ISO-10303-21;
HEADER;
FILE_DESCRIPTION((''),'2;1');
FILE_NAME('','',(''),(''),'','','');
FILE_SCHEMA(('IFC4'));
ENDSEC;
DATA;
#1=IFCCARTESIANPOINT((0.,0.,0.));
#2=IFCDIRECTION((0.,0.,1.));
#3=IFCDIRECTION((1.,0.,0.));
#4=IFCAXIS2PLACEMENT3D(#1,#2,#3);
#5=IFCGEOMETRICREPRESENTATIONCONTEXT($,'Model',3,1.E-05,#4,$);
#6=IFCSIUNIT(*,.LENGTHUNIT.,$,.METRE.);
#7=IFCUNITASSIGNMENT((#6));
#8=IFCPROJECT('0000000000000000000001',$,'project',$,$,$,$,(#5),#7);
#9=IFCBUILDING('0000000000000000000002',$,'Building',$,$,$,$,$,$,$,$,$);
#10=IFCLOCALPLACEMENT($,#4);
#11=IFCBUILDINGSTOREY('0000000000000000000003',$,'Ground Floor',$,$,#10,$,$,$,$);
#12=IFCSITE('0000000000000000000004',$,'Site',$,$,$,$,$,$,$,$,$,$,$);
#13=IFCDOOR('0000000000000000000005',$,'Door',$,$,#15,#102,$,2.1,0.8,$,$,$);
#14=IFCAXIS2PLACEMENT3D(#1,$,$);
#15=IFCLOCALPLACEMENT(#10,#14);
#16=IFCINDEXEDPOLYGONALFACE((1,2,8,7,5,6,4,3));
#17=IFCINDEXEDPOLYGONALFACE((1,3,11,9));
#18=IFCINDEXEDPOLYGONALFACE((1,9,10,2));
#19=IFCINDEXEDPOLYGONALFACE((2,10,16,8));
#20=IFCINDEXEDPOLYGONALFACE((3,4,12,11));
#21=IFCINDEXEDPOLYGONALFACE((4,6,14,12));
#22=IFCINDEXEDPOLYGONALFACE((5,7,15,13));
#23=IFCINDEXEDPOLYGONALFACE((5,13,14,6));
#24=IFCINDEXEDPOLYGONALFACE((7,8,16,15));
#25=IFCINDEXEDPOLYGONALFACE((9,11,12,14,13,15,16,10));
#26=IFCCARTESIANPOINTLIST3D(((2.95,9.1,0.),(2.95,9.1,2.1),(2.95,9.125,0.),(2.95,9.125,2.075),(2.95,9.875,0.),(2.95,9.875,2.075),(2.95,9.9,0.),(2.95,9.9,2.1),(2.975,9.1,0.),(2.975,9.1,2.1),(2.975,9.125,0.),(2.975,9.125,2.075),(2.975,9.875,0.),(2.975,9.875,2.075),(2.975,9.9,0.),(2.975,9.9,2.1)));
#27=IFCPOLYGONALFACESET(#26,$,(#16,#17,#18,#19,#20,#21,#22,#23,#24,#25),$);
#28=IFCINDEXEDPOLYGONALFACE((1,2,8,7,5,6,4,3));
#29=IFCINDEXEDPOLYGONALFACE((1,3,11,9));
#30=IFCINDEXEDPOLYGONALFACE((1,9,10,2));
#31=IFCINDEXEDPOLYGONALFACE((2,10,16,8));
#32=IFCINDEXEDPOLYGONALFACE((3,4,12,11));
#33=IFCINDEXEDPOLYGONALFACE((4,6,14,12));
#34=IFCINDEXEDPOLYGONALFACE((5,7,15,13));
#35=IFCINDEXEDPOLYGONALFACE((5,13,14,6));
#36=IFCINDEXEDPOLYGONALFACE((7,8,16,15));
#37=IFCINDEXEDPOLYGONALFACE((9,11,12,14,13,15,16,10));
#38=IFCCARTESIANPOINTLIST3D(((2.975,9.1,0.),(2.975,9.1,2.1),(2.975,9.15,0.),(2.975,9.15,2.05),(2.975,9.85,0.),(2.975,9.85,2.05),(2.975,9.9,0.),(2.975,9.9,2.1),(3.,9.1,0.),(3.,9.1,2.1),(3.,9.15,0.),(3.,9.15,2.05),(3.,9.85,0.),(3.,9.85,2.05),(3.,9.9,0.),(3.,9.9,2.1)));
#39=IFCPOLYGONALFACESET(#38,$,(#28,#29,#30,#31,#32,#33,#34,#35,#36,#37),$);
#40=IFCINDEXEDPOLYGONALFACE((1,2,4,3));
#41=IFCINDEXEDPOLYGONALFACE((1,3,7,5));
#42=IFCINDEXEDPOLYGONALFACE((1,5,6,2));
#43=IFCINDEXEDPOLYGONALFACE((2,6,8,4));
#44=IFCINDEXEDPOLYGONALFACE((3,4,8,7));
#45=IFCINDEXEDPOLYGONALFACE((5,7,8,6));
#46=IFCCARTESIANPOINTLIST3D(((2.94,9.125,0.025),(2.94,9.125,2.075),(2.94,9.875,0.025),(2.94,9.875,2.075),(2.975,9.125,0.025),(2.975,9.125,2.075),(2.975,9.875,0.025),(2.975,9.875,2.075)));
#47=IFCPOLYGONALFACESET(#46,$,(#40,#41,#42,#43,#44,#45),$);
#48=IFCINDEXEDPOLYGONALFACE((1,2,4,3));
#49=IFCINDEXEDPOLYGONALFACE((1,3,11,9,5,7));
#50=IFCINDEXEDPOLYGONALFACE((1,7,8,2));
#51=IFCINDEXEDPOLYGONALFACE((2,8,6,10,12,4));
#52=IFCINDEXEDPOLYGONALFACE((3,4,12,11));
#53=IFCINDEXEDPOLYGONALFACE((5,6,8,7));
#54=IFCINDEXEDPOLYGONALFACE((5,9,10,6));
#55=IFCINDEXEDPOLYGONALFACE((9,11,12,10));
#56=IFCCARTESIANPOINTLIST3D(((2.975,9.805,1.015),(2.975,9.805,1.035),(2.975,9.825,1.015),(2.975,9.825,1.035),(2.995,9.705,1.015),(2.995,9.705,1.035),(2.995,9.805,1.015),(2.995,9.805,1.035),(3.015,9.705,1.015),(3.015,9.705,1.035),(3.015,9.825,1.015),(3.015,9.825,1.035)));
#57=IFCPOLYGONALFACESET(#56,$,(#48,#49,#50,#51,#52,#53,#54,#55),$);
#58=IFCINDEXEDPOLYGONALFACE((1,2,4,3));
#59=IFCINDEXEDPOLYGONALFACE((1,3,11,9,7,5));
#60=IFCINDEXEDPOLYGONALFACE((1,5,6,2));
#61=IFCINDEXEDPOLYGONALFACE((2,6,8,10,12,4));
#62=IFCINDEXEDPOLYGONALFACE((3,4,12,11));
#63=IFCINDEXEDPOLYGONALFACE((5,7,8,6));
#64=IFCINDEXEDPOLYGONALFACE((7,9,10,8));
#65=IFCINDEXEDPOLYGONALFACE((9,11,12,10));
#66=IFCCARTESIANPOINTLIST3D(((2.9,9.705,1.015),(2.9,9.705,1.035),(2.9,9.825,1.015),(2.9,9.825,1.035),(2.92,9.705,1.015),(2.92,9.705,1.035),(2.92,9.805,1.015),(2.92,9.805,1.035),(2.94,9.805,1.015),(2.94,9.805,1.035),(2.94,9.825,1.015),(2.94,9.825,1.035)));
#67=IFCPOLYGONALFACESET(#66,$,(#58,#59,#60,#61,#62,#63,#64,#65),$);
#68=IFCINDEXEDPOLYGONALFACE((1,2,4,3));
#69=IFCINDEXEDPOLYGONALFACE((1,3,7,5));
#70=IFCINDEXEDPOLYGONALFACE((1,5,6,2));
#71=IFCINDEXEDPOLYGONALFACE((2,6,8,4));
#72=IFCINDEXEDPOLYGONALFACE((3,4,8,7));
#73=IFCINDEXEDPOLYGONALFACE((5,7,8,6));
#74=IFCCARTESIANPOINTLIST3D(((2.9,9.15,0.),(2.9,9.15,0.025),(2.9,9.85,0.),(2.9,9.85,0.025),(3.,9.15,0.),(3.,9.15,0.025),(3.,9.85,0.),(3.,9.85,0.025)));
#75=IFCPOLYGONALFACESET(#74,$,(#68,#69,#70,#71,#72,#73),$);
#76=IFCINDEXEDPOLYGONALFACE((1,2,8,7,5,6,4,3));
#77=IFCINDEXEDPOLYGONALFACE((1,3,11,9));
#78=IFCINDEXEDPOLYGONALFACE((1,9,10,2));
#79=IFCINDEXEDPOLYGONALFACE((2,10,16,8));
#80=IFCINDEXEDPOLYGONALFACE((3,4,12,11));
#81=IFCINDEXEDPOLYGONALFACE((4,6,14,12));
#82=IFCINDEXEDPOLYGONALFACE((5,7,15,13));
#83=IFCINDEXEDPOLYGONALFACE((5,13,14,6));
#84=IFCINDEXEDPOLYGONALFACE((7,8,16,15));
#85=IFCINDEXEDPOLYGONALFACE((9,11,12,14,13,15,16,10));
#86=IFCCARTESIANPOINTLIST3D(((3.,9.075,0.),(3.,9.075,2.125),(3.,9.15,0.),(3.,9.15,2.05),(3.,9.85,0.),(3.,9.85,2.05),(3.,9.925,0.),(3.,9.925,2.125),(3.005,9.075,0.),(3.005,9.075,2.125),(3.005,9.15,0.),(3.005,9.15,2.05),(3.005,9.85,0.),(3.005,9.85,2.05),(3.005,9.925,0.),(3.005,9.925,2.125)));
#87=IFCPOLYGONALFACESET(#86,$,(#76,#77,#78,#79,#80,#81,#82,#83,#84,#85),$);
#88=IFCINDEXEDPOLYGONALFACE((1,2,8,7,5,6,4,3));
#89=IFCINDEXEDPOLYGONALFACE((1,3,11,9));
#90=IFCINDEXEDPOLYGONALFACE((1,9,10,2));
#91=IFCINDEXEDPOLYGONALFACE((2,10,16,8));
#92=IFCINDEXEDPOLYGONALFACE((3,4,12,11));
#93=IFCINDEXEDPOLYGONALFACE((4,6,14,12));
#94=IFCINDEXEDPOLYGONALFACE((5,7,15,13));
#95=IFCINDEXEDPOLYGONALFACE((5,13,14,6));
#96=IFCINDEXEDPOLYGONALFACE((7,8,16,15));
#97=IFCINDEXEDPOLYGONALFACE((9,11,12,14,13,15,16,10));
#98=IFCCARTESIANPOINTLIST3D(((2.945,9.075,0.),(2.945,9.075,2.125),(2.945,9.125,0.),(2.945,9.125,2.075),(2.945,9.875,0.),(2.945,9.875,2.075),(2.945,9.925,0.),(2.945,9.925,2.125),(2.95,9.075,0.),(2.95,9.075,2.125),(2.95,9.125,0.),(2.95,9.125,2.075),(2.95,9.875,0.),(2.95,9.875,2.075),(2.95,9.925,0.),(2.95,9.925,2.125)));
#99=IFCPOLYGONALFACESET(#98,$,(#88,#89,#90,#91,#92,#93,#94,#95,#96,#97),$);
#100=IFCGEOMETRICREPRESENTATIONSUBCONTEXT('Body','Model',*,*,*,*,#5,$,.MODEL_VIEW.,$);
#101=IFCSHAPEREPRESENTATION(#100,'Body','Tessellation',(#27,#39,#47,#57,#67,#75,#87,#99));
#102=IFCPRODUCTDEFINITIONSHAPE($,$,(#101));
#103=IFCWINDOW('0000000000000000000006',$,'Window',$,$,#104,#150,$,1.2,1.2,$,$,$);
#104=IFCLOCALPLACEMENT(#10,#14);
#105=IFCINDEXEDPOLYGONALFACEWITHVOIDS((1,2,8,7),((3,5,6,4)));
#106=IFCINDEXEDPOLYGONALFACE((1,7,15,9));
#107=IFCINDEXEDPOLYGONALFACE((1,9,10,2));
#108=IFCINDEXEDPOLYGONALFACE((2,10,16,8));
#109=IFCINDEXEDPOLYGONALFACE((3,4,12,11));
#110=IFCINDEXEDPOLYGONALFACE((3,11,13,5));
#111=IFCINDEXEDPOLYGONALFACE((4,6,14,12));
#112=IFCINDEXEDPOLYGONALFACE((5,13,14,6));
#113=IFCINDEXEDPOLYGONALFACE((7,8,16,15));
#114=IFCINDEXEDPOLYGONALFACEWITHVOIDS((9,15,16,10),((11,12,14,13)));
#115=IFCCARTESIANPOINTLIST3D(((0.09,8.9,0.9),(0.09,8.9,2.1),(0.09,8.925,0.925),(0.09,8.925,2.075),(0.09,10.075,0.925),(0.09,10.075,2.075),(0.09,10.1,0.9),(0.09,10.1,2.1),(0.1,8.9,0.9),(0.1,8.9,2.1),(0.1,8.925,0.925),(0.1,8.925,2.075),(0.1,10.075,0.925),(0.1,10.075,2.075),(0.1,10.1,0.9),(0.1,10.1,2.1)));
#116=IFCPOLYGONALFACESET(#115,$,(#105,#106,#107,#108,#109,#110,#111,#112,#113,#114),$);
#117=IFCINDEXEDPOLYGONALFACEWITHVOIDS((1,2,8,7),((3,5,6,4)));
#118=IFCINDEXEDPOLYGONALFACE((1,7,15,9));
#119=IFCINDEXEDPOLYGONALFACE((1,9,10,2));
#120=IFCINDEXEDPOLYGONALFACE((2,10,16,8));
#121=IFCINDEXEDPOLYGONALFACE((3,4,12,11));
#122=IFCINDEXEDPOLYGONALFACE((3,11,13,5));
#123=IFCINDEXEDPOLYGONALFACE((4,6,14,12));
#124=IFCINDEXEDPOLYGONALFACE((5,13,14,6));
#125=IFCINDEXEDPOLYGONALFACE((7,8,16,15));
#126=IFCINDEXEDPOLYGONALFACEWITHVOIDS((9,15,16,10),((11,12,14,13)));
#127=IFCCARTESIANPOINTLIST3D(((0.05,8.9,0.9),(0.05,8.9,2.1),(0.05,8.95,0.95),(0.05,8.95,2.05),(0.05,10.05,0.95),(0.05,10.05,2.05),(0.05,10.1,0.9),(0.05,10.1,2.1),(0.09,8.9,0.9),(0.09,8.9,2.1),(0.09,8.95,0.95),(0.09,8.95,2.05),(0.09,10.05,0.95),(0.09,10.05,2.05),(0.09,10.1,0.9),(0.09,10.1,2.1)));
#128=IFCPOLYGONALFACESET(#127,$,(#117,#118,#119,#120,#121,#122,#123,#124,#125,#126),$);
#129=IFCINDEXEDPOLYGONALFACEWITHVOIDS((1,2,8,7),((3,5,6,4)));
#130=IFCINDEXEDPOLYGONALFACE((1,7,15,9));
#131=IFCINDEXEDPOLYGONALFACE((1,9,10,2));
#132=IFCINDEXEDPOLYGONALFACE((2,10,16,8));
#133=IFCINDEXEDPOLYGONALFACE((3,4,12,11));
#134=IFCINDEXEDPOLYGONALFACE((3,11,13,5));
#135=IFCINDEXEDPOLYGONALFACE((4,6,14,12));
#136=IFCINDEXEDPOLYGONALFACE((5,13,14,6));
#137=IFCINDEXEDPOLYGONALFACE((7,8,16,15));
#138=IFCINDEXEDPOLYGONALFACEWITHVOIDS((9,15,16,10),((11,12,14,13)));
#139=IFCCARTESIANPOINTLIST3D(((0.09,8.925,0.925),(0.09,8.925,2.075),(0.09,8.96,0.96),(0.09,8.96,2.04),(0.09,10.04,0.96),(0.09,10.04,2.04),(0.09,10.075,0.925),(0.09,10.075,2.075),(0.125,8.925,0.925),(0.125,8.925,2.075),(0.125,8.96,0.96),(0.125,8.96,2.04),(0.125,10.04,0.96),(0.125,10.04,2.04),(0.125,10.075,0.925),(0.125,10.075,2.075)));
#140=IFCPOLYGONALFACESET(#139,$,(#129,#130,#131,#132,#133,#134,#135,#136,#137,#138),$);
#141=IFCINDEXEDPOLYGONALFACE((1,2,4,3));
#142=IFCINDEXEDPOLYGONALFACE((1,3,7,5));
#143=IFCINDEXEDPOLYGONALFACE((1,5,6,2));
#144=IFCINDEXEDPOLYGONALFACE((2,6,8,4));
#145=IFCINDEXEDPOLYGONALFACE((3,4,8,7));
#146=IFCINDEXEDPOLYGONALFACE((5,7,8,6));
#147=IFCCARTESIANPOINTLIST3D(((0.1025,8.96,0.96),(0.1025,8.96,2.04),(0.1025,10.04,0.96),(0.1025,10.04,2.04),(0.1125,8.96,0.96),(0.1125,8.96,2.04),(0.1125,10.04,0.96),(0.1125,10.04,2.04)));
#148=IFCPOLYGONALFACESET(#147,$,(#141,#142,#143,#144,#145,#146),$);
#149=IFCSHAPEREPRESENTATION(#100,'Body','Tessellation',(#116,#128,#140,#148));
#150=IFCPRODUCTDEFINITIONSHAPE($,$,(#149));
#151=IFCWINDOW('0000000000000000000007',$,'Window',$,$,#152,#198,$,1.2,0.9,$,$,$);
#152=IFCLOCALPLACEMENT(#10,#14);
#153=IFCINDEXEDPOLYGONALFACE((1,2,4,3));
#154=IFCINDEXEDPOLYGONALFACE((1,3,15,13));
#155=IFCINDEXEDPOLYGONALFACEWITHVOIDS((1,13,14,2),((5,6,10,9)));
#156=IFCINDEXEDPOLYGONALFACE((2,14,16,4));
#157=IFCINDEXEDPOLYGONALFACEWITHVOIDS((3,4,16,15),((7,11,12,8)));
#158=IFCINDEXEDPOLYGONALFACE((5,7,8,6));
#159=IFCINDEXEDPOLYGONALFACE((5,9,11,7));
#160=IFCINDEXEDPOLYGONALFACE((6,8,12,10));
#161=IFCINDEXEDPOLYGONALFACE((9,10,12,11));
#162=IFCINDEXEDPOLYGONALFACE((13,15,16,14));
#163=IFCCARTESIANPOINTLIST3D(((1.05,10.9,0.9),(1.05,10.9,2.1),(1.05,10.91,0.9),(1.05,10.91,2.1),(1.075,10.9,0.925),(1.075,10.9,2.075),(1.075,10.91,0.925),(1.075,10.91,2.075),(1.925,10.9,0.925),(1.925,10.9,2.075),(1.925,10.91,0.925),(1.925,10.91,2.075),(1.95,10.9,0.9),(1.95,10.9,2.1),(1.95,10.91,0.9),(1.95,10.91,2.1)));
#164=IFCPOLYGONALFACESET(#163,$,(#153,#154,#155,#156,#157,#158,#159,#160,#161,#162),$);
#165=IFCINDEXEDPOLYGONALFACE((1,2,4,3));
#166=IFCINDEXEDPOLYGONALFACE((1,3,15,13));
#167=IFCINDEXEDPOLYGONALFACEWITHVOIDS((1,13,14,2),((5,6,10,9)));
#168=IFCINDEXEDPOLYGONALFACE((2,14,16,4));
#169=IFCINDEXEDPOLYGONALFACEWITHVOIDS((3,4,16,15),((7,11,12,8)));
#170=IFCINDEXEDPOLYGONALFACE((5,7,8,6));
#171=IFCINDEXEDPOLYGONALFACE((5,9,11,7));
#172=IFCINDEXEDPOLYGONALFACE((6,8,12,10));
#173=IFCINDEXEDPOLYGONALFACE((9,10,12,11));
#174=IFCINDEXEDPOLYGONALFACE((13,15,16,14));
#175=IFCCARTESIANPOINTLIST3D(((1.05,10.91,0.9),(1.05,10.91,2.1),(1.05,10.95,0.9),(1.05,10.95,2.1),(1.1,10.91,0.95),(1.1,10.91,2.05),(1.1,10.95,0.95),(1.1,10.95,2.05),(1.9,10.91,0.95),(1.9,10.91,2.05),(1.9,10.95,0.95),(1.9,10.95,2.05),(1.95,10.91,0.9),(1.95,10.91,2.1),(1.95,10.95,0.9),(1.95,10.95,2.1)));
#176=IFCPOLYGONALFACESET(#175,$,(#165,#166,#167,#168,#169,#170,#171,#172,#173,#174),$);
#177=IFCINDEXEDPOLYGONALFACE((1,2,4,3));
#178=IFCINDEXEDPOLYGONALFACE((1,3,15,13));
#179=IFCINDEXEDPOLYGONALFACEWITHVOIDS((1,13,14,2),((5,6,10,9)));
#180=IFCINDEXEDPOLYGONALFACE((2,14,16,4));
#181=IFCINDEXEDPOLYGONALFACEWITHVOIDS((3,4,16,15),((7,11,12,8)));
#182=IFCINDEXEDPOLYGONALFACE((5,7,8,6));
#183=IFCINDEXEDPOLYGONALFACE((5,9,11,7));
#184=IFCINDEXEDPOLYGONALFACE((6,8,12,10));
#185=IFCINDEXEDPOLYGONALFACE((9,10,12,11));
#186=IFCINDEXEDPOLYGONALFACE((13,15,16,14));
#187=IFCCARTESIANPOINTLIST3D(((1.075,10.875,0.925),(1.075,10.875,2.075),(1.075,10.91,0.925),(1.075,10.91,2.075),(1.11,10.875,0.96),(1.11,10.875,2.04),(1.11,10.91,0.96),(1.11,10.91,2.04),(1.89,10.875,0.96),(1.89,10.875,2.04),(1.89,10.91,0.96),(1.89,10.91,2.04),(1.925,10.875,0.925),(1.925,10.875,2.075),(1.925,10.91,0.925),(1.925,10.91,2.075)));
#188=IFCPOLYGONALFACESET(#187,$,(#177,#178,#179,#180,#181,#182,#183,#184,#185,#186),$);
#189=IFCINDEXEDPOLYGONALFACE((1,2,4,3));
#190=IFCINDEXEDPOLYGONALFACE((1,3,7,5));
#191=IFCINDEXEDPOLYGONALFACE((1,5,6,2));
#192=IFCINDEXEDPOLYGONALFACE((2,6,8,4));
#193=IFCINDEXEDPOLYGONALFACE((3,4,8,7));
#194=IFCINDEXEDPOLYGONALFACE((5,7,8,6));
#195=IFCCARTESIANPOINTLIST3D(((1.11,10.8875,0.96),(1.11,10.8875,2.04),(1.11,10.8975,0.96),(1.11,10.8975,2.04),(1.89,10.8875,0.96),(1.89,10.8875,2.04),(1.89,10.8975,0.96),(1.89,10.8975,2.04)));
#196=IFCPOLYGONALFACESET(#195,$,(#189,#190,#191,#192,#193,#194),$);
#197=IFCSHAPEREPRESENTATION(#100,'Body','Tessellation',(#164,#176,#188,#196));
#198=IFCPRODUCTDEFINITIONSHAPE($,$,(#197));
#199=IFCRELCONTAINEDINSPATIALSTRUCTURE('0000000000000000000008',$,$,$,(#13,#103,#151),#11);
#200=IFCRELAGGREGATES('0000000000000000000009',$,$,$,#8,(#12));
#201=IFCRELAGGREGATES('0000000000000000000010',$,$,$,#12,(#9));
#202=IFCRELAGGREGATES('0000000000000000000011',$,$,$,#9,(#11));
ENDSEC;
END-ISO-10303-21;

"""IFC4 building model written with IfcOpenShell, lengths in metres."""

from ifc_helpers import new_model, si_unit, frame, origin_with_axes, place, context, subcontext, project, spatial, line, indexed_curve, outline, extrude, element, save


model = new_model("IFC4")

# Units and contexts
model_context = context("Model", 3, precision=1e-05, world=origin_with_axes())
body_context = subcontext(model_context, "Body", "Model", "MODEL_VIEW")
ifc_project = project(units=[si_unit("LENGTHUNIT", "METRE")], contexts=[model_context])

# Site, building, storey
site = spatial("IfcSite", under=ifc_project, Name="Site")
building = spatial("IfcBuilding", under=site, Name="Building")
storey_placement = place(None, origin_with_axes())
storey = spatial("IfcBuildingStorey", under=building, at=storey_placement, Name="Ground Floor")

# Door
door_1_placement = place(storey_placement, frame((3.0, 9.1, 0.0), z_axis=(0.0, 0.0, 1.0), x_axis=(0.0, 1.0, 0.0)))
element("IfcDoor", 1, at=door_1_placement, inside=storey, Name="Door", OverallHeight=2.1, OverallWidth=0.8, context=body_context, shape_type="SweptSolid", body=[
    extrude(outline(indexed_curve([(0.0, 0.0), (0.0, 2.1), (0.8, 2.1), (0.8, 0.0), (0.775, 0.0), (0.775, 2.075), (0.025, 2.075), (0.025, 0.0)], segments=[line(1, 2, 3, 4, 5, 6, 7, 8, 1)])), frame((0.0, 0.025, 0.0), z_axis=(0.0, -1.0, 0.0), x_axis=(1.0, 0.0, 0.0)), (0.0, 0.0, -1.0), 0.025),
    extrude(outline(indexed_curve([(0.0, 0.0), (0.0, 2.1), (0.8, 2.1), (0.8, 0.0), (0.75, 0.0), (0.75, 2.05), (0.05, 2.05), (0.05, 0.0)], segments=[line(1, 2, 3, 4, 5, 6, 7, 8, 1)])), frame((0.0, 0.0, 0.0), z_axis=(0.0, -1.0, 0.0), x_axis=(1.0, 0.0, 0.0)), (0.0, 0.0, -1.0), 0.025),
    extrude(outline(indexed_curve([(0.0, 0.0), (0.75, 0.0), (0.75, 0.035), (0.0, 0.035)], segments=[line(1, 2, 3, 4, 1)])), frame((0.025, 0.025, 0.025), z_axis=(0.0, 0.0, 1.0), x_axis=(1.0, 0.0, 0.0)), (0.0, 0.0, 1.0), 2.05),
    extrude(outline(indexed_curve([(0.0, 0.0), (0.0, -0.04), (-0.12, -0.04), (-0.12, -0.02), (-0.02, -0.02), (-0.02, 0.0)], segments=[line(1, 2, 3, 4, 5, 6, 1)])), frame((0.725, 0.025, 1.015), z_axis=(0.0, 0.0, 1.0), x_axis=(1.0, 0.0, 0.0)), (0.0, 0.0, 1.0), 0.02),
    extrude(outline(indexed_curve([(0.0, 0.0), (0.0, 0.04), (-0.12, 0.04), (-0.12, 0.02), (-0.02, 0.02), (-0.02, 0.0)], segments=[line(1, 2, 3, 4, 5, 6, 1)])), frame((0.725, 0.06, 1.015), z_axis=(0.0, 0.0, 1.0), x_axis=(1.0, 0.0, 0.0)), (0.0, 0.0, 1.0), 0.02),
    extrude(outline(indexed_curve([(0.0, 0.0), (0.7, 0.0), (0.7, 0.1), (0.0, 0.1)], segments=[line(1, 2, 3, 4, 1)])), frame((0.05, 0.0, 0.0), z_axis=(0.0, 0.0, 1.0), x_axis=(1.0, 0.0, 0.0)), (0.0, 0.0, 1.0), 0.025),
    extrude(outline(indexed_curve([(0.0, 0.0), (0.0, 2.125), (0.85, 2.125), (0.85, 0.0), (0.775, 0.0), (0.775, 2.05), (0.075, 2.05), (0.075, 0.0)], segments=[line(1, 2, 3, 4, 5, 6, 7, 8, 1)])), frame((-0.025, -0.005, 0.0), z_axis=(0.0, -1.0, 0.0), x_axis=(1.0, 0.0, 0.0)), (0.0, 0.0, -1.0), 0.005),
    extrude(outline(indexed_curve([(0.0, 0.0), (0.0, 2.125), (0.85, 2.125), (0.85, 0.0), (0.8, 0.0), (0.8, 2.075), (0.05, 2.075), (0.05, 0.0)], segments=[line(1, 2, 3, 4, 5, 6, 7, 8, 1)])), frame((-0.025, 0.05, 0.0), z_axis=(0.0, -1.0, 0.0), x_axis=(1.0, 0.0, 0.0)), (0.0, 0.0, -1.0), 0.005),
])

# Windows
window_1_placement = place(storey_placement, frame((0.0, 10.1, 0.9), z_axis=(0.0, 0.0, 1.0), x_axis=(0.0, -1.0, 0.0)))
element("IfcWindow", 2, at=window_1_placement, inside=storey, Name="Window", OverallHeight=1.2, OverallWidth=1.2, context=body_context, shape_type="SweptSolid", body=[
    extrude(outline(indexed_curve([(0.0, 0.0), (1.2, 0.0), (1.2, 1.2), (0.0, 1.2)], segments=[line(1, 2, 3, 4, 1)]), holes=[indexed_curve([(0.025, 0.025), (1.175, 0.025), (1.175, 1.175), (0.025, 1.175)], segments=[line(1, 2, 3, 4, 1)])]), frame((0.0, 0.09, 0.0), z_axis=(0.0, -1.0, 0.0), x_axis=(1.0, 0.0, 0.0)), (0.0, 0.0, -1.0), 0.01),
    extrude(outline(indexed_curve([(0.0, 0.0), (1.2, 0.0), (1.2, 1.2), (0.0, 1.2)], segments=[line(1, 2, 3, 4, 1)]), holes=[indexed_curve([(0.05, 0.05), (1.15, 0.05), (1.15, 1.15), (0.05, 1.15)], segments=[line(1, 2, 3, 4, 1)])]), frame((0.0, 0.05, 0.0), z_axis=(0.0, -1.0, 0.0), x_axis=(1.0, 0.0, 0.0)), (0.0, 0.0, -1.0), 0.04),
    extrude(outline(indexed_curve([(0.0, 0.0), (1.15, 0.0), (1.15, 1.15), (0.0, 1.15)], segments=[line(1, 2, 3, 4, 1)]), holes=[indexed_curve([(0.035, 0.035), (1.115, 0.035), (1.115, 1.115), (0.035, 1.115)], segments=[line(1, 2, 3, 4, 1)])]), frame((0.025, 0.09, 0.025), z_axis=(0.0, -1.0, 0.0), x_axis=(1.0, 0.0, 0.0)), (0.0, 0.0, -1.0), 0.035),
    extrude(outline(indexed_curve([(0.035, 0.035), (1.115, 0.035), (1.115, 1.115), (0.035, 1.115)], segments=[line(1, 2, 3, 4, 1)])), frame((0.025, 0.1025, 0.025), z_axis=(0.0, -1.0, 0.0), x_axis=(1.0, 0.0, 0.0)), (0.0, 0.0, -1.0), 0.01),
])
for number, where, z_axis, x_axis, name in (
    (3, (1.95, 11.0, 0.9), (0.0, 0.0, 1.0), (-1.0, 0.0, 0.0), "Window"),
):
    element("IfcWindow", number, at=place(storey_placement, frame(where, z_axis=z_axis, x_axis=x_axis)), inside=storey, Name=name, OverallHeight=1.2, OverallWidth=0.9, context=body_context, shape_type="SweptSolid", body=[
        extrude(outline(indexed_curve([(0.0, 0.0), (0.9, 0.0), (0.9, 1.2), (0.0, 1.2)], segments=[line(1, 2, 3, 4, 1)]), holes=[indexed_curve([(0.025, 0.025), (0.875, 0.025), (0.875, 1.175), (0.025, 1.175)], segments=[line(1, 2, 3, 4, 1)])]), frame((0.0, 0.09, 0.0), z_axis=(0.0, -1.0, 0.0), x_axis=(1.0, 0.0, 0.0)), (0.0, 0.0, -1.0), 0.01),
        extrude(outline(indexed_curve([(0.0, 0.0), (0.9, 0.0), (0.9, 1.2), (0.0, 1.2)], segments=[line(1, 2, 3, 4, 1)]), holes=[indexed_curve([(0.05, 0.05), (0.85, 0.05), (0.85, 1.15), (0.05, 1.15)], segments=[line(1, 2, 3, 4, 1)])]), frame((0.0, 0.05, 0.0), z_axis=(0.0, -1.0, 0.0), x_axis=(1.0, 0.0, 0.0)), (0.0, 0.0, -1.0), 0.04),
        extrude(outline(indexed_curve([(0.0, 0.0), (0.85, 0.0), (0.85, 1.15), (0.0, 1.15)], segments=[line(1, 2, 3, 4, 1)]), holes=[indexed_curve([(0.035, 0.035), (0.815, 0.035), (0.815, 1.115), (0.035, 1.115)], segments=[line(1, 2, 3, 4, 1)])]), frame((0.025, 0.09, 0.025), z_axis=(0.0, -1.0, 0.0), x_axis=(1.0, 0.0, 0.0)), (0.0, 0.0, -1.0), 0.035),
        extrude(outline(indexed_curve([(0.035, 0.035), (0.815, 0.035), (0.815, 1.115), (0.035, 1.115)], segments=[line(1, 2, 3, 4, 1)])), frame((0.025, 0.1025, 0.025), z_axis=(0.0, -1.0, 0.0), x_axis=(1.0, 0.0, 0.0)), (0.0, 0.0, -1.0), 0.01),
    ])

save(model, "model.ifc")
